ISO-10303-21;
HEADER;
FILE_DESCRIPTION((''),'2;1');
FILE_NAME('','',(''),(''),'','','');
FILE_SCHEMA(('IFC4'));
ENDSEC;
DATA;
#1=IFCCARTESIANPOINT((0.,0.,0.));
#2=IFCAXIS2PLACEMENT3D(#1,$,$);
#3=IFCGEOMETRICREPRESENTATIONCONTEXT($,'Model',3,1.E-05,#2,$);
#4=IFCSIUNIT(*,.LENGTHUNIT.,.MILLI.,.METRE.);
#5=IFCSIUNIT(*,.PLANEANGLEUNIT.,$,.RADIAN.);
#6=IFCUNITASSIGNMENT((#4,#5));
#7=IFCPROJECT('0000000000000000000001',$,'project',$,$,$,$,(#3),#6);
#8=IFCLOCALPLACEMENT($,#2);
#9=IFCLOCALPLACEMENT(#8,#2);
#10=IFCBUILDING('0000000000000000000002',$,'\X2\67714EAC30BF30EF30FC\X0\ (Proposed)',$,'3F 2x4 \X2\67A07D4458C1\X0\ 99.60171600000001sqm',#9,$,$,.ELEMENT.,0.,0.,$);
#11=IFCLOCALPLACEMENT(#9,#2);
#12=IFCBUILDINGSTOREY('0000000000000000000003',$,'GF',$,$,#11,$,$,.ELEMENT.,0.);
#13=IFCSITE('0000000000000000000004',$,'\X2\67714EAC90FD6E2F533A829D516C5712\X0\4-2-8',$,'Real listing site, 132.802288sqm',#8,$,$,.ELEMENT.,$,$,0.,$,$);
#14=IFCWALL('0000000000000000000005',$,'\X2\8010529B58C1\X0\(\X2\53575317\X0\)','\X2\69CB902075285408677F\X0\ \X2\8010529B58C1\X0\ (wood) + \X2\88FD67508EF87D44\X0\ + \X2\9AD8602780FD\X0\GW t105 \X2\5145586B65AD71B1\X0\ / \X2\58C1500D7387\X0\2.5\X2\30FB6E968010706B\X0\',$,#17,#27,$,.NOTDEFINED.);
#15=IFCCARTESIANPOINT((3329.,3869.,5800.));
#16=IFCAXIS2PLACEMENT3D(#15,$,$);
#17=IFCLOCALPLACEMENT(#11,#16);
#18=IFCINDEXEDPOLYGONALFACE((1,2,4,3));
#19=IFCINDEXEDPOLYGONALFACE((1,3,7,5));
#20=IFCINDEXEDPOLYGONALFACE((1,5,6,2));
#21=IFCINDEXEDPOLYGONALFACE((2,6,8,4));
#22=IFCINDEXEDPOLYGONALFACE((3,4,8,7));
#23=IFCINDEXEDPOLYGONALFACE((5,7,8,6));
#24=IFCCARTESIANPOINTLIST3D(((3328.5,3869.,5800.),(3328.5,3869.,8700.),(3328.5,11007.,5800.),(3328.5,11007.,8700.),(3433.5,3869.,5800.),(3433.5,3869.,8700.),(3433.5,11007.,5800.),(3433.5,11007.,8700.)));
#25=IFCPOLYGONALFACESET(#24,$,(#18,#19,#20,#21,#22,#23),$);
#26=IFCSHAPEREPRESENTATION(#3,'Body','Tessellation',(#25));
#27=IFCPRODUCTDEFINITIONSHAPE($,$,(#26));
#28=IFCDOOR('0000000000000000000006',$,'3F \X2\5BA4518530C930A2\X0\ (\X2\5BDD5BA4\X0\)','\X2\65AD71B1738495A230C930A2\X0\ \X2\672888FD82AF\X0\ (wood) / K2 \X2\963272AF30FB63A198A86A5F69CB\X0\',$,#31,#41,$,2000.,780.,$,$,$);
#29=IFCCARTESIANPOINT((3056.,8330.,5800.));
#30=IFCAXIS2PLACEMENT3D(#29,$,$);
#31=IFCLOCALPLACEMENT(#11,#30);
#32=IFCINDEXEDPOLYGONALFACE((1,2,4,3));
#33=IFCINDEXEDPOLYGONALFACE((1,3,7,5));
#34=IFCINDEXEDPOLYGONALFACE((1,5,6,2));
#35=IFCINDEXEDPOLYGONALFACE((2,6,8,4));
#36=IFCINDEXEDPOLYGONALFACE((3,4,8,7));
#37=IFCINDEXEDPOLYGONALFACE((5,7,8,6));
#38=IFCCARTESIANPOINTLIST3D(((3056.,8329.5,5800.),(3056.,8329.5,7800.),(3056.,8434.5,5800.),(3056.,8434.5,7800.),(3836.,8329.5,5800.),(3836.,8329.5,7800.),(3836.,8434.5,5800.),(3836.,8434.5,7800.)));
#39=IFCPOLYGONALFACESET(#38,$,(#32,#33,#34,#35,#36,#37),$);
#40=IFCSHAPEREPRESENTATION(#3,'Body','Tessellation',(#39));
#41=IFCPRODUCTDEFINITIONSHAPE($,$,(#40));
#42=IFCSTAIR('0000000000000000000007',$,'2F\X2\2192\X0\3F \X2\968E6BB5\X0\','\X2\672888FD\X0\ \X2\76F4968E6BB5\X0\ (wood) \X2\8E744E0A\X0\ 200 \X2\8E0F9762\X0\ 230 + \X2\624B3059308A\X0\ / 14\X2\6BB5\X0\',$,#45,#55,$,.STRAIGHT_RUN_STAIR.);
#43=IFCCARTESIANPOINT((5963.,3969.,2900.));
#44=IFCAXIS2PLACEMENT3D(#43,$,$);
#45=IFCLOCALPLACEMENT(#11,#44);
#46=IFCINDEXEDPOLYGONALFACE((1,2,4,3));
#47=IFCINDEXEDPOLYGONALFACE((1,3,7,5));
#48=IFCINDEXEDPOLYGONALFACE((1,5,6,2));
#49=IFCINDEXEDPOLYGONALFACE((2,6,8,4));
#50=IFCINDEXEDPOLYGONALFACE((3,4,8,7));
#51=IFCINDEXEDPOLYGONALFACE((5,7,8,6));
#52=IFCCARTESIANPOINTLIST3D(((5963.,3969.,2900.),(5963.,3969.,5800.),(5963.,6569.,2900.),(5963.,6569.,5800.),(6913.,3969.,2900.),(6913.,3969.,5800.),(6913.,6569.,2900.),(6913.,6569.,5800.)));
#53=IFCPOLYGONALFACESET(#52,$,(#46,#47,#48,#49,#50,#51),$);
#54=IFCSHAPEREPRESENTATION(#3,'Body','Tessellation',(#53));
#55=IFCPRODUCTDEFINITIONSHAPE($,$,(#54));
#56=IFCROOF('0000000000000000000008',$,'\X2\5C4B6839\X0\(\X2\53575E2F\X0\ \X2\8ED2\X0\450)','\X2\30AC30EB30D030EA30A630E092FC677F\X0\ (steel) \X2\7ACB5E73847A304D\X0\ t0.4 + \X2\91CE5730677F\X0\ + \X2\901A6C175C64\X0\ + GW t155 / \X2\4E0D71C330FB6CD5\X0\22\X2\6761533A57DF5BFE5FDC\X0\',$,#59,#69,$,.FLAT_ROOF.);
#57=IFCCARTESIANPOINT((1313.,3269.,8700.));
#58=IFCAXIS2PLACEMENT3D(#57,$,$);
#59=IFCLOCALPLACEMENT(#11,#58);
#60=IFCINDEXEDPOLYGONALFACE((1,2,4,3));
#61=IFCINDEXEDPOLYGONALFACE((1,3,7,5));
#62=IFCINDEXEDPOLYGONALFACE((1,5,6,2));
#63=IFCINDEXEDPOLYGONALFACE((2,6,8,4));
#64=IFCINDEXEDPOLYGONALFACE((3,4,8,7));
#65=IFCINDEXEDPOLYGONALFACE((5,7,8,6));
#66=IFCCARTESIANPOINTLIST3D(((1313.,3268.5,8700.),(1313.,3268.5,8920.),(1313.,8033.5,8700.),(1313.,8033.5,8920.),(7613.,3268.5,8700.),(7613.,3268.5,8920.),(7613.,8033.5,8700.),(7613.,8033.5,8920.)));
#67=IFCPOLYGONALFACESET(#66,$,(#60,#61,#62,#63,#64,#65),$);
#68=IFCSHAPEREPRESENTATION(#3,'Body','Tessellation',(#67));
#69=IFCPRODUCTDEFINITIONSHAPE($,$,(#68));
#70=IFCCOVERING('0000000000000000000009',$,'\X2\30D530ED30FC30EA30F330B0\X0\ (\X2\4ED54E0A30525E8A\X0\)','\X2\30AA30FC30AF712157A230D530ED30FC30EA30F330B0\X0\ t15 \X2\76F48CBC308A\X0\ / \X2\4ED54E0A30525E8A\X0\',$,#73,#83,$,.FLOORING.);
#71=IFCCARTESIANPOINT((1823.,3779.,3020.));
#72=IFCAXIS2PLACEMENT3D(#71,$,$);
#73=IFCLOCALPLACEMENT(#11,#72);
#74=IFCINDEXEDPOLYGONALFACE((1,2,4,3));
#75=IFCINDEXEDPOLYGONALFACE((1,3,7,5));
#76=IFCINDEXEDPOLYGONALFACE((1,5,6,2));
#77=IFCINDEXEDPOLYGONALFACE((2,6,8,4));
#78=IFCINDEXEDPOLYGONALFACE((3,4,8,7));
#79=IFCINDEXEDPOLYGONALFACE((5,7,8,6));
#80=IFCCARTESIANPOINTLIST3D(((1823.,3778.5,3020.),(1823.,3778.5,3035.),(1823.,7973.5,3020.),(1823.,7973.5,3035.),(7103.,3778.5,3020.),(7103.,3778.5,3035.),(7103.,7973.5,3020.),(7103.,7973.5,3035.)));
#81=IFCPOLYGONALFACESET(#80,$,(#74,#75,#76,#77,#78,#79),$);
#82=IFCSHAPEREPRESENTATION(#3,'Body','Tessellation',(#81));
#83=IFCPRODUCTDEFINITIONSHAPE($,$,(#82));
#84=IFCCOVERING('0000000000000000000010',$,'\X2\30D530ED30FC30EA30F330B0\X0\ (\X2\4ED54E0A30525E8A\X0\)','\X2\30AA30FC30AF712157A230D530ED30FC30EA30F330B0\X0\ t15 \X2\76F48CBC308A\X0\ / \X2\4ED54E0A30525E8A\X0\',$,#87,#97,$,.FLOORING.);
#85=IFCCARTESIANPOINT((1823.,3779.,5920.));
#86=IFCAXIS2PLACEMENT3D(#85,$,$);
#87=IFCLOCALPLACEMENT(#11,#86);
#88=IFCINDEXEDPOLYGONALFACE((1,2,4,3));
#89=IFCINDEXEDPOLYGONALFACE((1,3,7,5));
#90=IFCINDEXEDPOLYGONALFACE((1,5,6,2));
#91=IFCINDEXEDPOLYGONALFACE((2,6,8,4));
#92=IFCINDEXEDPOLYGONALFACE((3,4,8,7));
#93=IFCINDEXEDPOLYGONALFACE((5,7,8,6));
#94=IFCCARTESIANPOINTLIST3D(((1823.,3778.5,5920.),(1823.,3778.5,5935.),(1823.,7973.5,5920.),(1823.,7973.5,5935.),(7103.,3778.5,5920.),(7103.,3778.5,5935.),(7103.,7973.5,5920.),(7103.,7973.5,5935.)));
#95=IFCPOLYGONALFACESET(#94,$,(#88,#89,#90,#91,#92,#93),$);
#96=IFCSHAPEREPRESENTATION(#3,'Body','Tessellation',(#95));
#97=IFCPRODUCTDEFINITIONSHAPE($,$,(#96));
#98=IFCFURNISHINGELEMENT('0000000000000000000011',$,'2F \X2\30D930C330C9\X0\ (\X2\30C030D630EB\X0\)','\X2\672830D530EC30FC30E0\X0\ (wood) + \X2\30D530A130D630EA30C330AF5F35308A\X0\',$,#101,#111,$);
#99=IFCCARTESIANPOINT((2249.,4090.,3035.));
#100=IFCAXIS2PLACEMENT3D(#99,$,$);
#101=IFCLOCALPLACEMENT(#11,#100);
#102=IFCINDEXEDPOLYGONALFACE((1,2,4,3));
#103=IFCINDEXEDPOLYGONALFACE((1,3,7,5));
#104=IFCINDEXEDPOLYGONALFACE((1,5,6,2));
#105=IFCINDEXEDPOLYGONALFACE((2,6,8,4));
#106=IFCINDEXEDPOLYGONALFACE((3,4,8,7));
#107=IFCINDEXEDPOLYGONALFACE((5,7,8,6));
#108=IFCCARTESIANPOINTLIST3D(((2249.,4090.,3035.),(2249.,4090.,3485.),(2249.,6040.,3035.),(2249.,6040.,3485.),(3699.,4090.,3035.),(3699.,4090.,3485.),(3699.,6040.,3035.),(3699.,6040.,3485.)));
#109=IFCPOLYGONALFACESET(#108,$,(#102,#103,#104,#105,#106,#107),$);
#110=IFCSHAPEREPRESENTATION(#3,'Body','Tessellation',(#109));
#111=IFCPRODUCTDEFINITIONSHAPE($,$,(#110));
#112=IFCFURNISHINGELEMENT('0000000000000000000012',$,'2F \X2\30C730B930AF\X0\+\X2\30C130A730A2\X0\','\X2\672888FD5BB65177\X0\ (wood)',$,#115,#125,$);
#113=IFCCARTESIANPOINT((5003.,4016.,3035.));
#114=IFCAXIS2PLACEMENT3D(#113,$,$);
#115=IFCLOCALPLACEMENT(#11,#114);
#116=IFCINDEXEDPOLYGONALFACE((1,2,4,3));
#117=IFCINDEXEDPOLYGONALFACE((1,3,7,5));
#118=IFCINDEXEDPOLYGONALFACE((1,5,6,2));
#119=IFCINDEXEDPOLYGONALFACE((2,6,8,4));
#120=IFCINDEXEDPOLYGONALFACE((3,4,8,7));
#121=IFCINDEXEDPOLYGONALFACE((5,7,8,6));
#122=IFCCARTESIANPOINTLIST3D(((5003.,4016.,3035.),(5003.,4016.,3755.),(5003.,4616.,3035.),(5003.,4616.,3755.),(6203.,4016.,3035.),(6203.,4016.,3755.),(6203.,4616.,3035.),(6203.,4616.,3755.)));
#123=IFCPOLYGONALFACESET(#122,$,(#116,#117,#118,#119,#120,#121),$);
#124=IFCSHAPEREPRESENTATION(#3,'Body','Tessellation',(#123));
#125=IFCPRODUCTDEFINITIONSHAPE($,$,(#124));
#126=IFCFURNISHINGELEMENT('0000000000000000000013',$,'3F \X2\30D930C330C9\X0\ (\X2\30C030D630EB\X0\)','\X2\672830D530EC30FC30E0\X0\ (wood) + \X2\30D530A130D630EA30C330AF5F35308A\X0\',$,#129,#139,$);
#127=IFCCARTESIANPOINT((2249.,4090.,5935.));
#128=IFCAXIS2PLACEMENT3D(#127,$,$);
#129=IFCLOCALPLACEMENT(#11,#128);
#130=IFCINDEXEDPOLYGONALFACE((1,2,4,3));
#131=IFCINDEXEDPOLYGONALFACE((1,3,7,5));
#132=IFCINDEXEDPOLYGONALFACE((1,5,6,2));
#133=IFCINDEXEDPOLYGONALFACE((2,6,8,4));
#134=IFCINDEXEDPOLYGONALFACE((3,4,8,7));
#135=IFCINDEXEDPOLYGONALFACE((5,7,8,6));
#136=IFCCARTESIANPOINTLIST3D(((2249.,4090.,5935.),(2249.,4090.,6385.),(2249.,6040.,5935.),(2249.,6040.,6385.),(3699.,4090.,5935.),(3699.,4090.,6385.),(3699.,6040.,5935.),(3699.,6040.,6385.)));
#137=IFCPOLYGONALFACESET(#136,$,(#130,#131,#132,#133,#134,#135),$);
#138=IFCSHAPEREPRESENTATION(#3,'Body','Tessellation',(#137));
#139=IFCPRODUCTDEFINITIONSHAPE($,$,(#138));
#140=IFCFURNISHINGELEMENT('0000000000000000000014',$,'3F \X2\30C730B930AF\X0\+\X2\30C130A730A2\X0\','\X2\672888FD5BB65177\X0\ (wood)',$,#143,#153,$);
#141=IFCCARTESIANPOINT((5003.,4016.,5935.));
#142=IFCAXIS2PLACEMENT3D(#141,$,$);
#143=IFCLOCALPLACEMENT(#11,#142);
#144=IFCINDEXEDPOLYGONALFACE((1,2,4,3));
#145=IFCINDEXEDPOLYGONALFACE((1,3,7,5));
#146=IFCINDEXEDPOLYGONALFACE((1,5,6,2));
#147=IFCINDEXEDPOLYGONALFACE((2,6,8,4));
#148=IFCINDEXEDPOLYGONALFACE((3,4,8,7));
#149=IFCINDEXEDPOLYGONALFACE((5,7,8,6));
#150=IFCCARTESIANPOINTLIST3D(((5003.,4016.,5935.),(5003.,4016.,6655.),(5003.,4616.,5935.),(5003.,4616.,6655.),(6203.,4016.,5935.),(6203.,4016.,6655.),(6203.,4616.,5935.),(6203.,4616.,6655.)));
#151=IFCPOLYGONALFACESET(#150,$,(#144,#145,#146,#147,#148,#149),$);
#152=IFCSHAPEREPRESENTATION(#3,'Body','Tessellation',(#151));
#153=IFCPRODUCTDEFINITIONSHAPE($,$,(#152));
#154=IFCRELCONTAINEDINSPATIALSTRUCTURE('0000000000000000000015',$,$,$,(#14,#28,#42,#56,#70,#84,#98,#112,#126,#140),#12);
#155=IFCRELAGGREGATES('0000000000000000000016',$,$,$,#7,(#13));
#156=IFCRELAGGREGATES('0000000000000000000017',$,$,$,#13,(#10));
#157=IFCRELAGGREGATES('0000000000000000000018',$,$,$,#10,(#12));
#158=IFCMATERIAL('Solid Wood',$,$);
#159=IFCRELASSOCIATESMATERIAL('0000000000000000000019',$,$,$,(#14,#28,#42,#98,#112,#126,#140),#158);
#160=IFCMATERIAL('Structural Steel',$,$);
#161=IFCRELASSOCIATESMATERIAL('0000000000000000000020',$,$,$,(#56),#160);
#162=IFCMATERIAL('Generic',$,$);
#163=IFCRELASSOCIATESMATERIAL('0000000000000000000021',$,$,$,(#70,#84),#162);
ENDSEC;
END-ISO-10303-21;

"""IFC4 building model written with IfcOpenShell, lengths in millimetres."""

from ifc_helpers import new_model, si_unit, frame, frame_2d, origin, place, context, project, spatial, rectangle, extrude, material, element, fill, save


model = new_model("IFC4")

# Units and contexts
model_context = context("Model", 3, precision=1e-05, world=origin())
ifc_project = project(units=[si_unit("LENGTHUNIT", "METRE", prefix="MILLI"), si_unit("PLANEANGLEUNIT", "RADIAN")], contexts=[model_context])

# Site, building, storey
site_placement = place(None, origin())
site = spatial("IfcSite", under=ifc_project, at=site_placement, Name="東京都港区芝公園4-2-8", ObjectType="Real listing site, 132.802288sqm", CompositionType="ELEMENT", RefElevation=0.0)
building_placement = place(site_placement, origin())
building = spatial("IfcBuilding", under=site, at=building_placement, Name="東京タワー (Proposed)", ObjectType="3F 2x4 枠組壁 99.60171600000001sqm", CompositionType="ELEMENT", ElevationOfRefHeight=0.0, ElevationOfTerrain=0.0)
storey_placement = place(building_placement, origin())
storey = spatial("IfcBuildingStorey", under=building, at=storey_placement, Name="GF", CompositionType="ELEMENT", Elevation=0.0)

# Shared definitions
ifc_material_1 = material(Name="Solid Wood")

# Wall, opening, door
wall_1_placement = place(storey_placement, frame((3329.0, 3869.0, 5800.0)))
wall_1 = element("IfcWall", 1, at=wall_1_placement, inside=storey, material=ifc_material_1, Name="耐力壁(南北)", Description="構造用合板 耐力壁 (wood) + 製材軸組 + 高性能GW t105 充填断熱 / 壁倍率2.5・準耐火", PredefinedType="NOTDEFINED", context=model_context, shape_type="SweptSolid", body=[
    extrude(rectangle(XDim=105.0, YDim=7138.0, at=frame_2d((52.0, 3569.0))), frame((3329.0, 3869.0, 5800.0)), (0.0, 0.0, 1.0), 2900.0),
])
opening_1_placement = place(storey_placement, frame((3056.0, 8330.0, 5800.0)))
opening_1 = element("IfcOpeningElement", 2, at=opening_1_placement, cuts=wall_1, PredefinedType="NOTDEFINED", context=model_context, shape_type="SweptSolid", body=[
    extrude(rectangle(XDim=780.0, YDim=105.0, at=frame_2d((390.0, 52.0))), frame((3056.0, 8330.0, 5800.0)), (0.0, 0.0, 1.0), 2000.0),
])
door_1_placement = place(storey_placement, frame((3056.0, 8330.0, 5800.0)))
door_1 = element("IfcDoor", 3, at=door_1_placement, inside=storey, material=ifc_material_1, Name="3F 室内ドア (寝室)", Description="断熱玄関ドア 木製芯 (wood) / K2 防犯・採風機構", OverallHeight=2000.0, OverallWidth=780.0, context=model_context, shape_type="SweptSolid", body=[
    extrude(rectangle(XDim=780.0, YDim=105.0, at=frame_2d((390.0, 52.0))), frame((3056.0, 8330.0, 5800.0)), (0.0, 0.0, 1.0), 2000.0),
])
fill(opening_1, door_1)

# Stair
stair_placement = place(storey_placement, frame((5963.0, 3969.0, 2900.0)))
element("IfcStair", 4, at=stair_placement, inside=storey, material=ifc_material_1, Name="2F→3F 階段", Description="木製 直階段 (wood) 蹴上 200 踏面 230 + 手すり / 14段", PredefinedType="STRAIGHT_RUN_STAIR", context=model_context, shape_type="SweptSolid", body=[
    extrude(rectangle(XDim=950.0, YDim=2600.0, at=frame_2d((475.0, 1300.0))), frame((5963.0, 3969.0, 2900.0)), (0.0, 0.0, 1.0), 2900.0),
])

# Roof
ifc_material_2 = material(Name="Structural Steel")
for number, where, name in (
    (5, (1313.0, 3269.0, 8700.0), "屋根(南帯 軒450)"),
):
    element("IfcRoof", number, at=place(storey_placement, frame(where)), inside=storey, material=ifc_material_2, Name=name, Description="ガルバリウム鋼板 (steel) 立平葺き t0.4 + 野地板 + 通気層 + GW t155 / 不燃・法22条区域対応", PredefinedType="FLAT_ROOF", context=model_context, shape_type="SweptSolid", body=[
        extrude(rectangle(XDim=6300.0, YDim=4765.0, at=frame_2d((3150.0, 2382.0))), frame((1313.0, 3269.0, 8700.0)), (0.0, 0.0, 1.0), 220.0),
    ])

# Coverings
ifc_material_3 = material(Name="Generic")
covering_1_placement = place(storey_placement, frame((1823.0, 3779.0, 3020.0)))
element("IfcCovering", 6, at=covering_1_placement, inside=storey, material=ifc_material_3, Name="フローリング (仕上げ床)", Description="オーク無垢フローリング t15 直貼り / 仕上げ床", PredefinedType="FLOORING", context=model_context, shape_type="SweptSolid", body=[
    extrude(rectangle(XDim=5280.0, YDim=4195.0, at=frame_2d((2640.0, 2097.0))), frame((1823.0, 3779.0, 3020.0)), (0.0, 0.0, 1.0), 15.0),
])
covering_2_placement = place(storey_placement, frame((1823.0, 3779.0, 5920.0)))
element("IfcCovering", 7, at=covering_2_placement, inside=storey, material=ifc_material_3, Name="フローリング (仕上げ床)", Description="オーク無垢フローリング t15 直貼り / 仕上げ床", PredefinedType="FLOORING", context=model_context, shape_type="SweptSolid", body=[
    extrude(rectangle(XDim=5280.0, YDim=4195.0, at=frame_2d((2640.0, 2097.0))), frame((1823.0, 3779.0, 5920.0)), (0.0, 0.0, 1.0), 15.0),
])

# Furnishing elements
furnishing_1_placement = place(storey_placement, frame((2249.0, 4090.0, 3035.0)))
element("IfcFurnishingElement", 8, at=furnishing_1_placement, inside=storey, material=ifc_material_1, Name="2F ベッド (ダブル)", Description="木フレーム (wood) + ファブリック張り", context=model_context, shape_type="SweptSolid", body=[
    extrude(rectangle(XDim=1450.0, YDim=1950.0, at=frame_2d((725.0, 975.0))), frame((2249.0, 4090.0, 3035.0)), (0.0, 0.0, 1.0), 450.0),
])
furnishing_2_placement = place(storey_placement, frame((5003.0, 4016.0, 3035.0)))
element("IfcFurnishingElement", 9, at=furnishing_2_placement, inside=storey, material=ifc_material_1, Name="2F デスク+チェア", Description="木製家具 (wood)", context=model_context, shape_type="SweptSolid", body=[
    extrude(rectangle(XDim=1200.0, YDim=600.0, at=frame_2d((600.0, 300.0))), frame((5003.0, 4016.0, 3035.0)), (0.0, 0.0, 1.0), 720.0),
])
furnishing_3_placement = place(storey_placement, frame((2249.0, 4090.0, 5935.0)))
element("IfcFurnishingElement", 10, at=furnishing_3_placement, inside=storey, material=ifc_material_1, Name="3F ベッド (ダブル)", Description="木フレーム (wood) + ファブリック張り", context=model_context, shape_type="SweptSolid", body=[
    extrude(rectangle(XDim=1450.0, YDim=1950.0, at=frame_2d((725.0, 975.0))), frame((2249.0, 4090.0, 5935.0)), (0.0, 0.0, 1.0), 450.0),
])
furnishing_4_placement = place(storey_placement, frame((5003.0, 4016.0, 5935.0)))
element("IfcFurnishingElement", 11, at=furnishing_4_placement, inside=storey, material=ifc_material_1, Name="3F デスク+チェア", Description="木製家具 (wood)", context=model_context, shape_type="SweptSolid", body=[
    extrude(rectangle(XDim=1200.0, YDim=600.0, at=frame_2d((600.0, 300.0))), frame((5003.0, 4016.0, 5935.0)), (0.0, 0.0, 1.0), 720.0),
])

save(model, "model.ifc")
